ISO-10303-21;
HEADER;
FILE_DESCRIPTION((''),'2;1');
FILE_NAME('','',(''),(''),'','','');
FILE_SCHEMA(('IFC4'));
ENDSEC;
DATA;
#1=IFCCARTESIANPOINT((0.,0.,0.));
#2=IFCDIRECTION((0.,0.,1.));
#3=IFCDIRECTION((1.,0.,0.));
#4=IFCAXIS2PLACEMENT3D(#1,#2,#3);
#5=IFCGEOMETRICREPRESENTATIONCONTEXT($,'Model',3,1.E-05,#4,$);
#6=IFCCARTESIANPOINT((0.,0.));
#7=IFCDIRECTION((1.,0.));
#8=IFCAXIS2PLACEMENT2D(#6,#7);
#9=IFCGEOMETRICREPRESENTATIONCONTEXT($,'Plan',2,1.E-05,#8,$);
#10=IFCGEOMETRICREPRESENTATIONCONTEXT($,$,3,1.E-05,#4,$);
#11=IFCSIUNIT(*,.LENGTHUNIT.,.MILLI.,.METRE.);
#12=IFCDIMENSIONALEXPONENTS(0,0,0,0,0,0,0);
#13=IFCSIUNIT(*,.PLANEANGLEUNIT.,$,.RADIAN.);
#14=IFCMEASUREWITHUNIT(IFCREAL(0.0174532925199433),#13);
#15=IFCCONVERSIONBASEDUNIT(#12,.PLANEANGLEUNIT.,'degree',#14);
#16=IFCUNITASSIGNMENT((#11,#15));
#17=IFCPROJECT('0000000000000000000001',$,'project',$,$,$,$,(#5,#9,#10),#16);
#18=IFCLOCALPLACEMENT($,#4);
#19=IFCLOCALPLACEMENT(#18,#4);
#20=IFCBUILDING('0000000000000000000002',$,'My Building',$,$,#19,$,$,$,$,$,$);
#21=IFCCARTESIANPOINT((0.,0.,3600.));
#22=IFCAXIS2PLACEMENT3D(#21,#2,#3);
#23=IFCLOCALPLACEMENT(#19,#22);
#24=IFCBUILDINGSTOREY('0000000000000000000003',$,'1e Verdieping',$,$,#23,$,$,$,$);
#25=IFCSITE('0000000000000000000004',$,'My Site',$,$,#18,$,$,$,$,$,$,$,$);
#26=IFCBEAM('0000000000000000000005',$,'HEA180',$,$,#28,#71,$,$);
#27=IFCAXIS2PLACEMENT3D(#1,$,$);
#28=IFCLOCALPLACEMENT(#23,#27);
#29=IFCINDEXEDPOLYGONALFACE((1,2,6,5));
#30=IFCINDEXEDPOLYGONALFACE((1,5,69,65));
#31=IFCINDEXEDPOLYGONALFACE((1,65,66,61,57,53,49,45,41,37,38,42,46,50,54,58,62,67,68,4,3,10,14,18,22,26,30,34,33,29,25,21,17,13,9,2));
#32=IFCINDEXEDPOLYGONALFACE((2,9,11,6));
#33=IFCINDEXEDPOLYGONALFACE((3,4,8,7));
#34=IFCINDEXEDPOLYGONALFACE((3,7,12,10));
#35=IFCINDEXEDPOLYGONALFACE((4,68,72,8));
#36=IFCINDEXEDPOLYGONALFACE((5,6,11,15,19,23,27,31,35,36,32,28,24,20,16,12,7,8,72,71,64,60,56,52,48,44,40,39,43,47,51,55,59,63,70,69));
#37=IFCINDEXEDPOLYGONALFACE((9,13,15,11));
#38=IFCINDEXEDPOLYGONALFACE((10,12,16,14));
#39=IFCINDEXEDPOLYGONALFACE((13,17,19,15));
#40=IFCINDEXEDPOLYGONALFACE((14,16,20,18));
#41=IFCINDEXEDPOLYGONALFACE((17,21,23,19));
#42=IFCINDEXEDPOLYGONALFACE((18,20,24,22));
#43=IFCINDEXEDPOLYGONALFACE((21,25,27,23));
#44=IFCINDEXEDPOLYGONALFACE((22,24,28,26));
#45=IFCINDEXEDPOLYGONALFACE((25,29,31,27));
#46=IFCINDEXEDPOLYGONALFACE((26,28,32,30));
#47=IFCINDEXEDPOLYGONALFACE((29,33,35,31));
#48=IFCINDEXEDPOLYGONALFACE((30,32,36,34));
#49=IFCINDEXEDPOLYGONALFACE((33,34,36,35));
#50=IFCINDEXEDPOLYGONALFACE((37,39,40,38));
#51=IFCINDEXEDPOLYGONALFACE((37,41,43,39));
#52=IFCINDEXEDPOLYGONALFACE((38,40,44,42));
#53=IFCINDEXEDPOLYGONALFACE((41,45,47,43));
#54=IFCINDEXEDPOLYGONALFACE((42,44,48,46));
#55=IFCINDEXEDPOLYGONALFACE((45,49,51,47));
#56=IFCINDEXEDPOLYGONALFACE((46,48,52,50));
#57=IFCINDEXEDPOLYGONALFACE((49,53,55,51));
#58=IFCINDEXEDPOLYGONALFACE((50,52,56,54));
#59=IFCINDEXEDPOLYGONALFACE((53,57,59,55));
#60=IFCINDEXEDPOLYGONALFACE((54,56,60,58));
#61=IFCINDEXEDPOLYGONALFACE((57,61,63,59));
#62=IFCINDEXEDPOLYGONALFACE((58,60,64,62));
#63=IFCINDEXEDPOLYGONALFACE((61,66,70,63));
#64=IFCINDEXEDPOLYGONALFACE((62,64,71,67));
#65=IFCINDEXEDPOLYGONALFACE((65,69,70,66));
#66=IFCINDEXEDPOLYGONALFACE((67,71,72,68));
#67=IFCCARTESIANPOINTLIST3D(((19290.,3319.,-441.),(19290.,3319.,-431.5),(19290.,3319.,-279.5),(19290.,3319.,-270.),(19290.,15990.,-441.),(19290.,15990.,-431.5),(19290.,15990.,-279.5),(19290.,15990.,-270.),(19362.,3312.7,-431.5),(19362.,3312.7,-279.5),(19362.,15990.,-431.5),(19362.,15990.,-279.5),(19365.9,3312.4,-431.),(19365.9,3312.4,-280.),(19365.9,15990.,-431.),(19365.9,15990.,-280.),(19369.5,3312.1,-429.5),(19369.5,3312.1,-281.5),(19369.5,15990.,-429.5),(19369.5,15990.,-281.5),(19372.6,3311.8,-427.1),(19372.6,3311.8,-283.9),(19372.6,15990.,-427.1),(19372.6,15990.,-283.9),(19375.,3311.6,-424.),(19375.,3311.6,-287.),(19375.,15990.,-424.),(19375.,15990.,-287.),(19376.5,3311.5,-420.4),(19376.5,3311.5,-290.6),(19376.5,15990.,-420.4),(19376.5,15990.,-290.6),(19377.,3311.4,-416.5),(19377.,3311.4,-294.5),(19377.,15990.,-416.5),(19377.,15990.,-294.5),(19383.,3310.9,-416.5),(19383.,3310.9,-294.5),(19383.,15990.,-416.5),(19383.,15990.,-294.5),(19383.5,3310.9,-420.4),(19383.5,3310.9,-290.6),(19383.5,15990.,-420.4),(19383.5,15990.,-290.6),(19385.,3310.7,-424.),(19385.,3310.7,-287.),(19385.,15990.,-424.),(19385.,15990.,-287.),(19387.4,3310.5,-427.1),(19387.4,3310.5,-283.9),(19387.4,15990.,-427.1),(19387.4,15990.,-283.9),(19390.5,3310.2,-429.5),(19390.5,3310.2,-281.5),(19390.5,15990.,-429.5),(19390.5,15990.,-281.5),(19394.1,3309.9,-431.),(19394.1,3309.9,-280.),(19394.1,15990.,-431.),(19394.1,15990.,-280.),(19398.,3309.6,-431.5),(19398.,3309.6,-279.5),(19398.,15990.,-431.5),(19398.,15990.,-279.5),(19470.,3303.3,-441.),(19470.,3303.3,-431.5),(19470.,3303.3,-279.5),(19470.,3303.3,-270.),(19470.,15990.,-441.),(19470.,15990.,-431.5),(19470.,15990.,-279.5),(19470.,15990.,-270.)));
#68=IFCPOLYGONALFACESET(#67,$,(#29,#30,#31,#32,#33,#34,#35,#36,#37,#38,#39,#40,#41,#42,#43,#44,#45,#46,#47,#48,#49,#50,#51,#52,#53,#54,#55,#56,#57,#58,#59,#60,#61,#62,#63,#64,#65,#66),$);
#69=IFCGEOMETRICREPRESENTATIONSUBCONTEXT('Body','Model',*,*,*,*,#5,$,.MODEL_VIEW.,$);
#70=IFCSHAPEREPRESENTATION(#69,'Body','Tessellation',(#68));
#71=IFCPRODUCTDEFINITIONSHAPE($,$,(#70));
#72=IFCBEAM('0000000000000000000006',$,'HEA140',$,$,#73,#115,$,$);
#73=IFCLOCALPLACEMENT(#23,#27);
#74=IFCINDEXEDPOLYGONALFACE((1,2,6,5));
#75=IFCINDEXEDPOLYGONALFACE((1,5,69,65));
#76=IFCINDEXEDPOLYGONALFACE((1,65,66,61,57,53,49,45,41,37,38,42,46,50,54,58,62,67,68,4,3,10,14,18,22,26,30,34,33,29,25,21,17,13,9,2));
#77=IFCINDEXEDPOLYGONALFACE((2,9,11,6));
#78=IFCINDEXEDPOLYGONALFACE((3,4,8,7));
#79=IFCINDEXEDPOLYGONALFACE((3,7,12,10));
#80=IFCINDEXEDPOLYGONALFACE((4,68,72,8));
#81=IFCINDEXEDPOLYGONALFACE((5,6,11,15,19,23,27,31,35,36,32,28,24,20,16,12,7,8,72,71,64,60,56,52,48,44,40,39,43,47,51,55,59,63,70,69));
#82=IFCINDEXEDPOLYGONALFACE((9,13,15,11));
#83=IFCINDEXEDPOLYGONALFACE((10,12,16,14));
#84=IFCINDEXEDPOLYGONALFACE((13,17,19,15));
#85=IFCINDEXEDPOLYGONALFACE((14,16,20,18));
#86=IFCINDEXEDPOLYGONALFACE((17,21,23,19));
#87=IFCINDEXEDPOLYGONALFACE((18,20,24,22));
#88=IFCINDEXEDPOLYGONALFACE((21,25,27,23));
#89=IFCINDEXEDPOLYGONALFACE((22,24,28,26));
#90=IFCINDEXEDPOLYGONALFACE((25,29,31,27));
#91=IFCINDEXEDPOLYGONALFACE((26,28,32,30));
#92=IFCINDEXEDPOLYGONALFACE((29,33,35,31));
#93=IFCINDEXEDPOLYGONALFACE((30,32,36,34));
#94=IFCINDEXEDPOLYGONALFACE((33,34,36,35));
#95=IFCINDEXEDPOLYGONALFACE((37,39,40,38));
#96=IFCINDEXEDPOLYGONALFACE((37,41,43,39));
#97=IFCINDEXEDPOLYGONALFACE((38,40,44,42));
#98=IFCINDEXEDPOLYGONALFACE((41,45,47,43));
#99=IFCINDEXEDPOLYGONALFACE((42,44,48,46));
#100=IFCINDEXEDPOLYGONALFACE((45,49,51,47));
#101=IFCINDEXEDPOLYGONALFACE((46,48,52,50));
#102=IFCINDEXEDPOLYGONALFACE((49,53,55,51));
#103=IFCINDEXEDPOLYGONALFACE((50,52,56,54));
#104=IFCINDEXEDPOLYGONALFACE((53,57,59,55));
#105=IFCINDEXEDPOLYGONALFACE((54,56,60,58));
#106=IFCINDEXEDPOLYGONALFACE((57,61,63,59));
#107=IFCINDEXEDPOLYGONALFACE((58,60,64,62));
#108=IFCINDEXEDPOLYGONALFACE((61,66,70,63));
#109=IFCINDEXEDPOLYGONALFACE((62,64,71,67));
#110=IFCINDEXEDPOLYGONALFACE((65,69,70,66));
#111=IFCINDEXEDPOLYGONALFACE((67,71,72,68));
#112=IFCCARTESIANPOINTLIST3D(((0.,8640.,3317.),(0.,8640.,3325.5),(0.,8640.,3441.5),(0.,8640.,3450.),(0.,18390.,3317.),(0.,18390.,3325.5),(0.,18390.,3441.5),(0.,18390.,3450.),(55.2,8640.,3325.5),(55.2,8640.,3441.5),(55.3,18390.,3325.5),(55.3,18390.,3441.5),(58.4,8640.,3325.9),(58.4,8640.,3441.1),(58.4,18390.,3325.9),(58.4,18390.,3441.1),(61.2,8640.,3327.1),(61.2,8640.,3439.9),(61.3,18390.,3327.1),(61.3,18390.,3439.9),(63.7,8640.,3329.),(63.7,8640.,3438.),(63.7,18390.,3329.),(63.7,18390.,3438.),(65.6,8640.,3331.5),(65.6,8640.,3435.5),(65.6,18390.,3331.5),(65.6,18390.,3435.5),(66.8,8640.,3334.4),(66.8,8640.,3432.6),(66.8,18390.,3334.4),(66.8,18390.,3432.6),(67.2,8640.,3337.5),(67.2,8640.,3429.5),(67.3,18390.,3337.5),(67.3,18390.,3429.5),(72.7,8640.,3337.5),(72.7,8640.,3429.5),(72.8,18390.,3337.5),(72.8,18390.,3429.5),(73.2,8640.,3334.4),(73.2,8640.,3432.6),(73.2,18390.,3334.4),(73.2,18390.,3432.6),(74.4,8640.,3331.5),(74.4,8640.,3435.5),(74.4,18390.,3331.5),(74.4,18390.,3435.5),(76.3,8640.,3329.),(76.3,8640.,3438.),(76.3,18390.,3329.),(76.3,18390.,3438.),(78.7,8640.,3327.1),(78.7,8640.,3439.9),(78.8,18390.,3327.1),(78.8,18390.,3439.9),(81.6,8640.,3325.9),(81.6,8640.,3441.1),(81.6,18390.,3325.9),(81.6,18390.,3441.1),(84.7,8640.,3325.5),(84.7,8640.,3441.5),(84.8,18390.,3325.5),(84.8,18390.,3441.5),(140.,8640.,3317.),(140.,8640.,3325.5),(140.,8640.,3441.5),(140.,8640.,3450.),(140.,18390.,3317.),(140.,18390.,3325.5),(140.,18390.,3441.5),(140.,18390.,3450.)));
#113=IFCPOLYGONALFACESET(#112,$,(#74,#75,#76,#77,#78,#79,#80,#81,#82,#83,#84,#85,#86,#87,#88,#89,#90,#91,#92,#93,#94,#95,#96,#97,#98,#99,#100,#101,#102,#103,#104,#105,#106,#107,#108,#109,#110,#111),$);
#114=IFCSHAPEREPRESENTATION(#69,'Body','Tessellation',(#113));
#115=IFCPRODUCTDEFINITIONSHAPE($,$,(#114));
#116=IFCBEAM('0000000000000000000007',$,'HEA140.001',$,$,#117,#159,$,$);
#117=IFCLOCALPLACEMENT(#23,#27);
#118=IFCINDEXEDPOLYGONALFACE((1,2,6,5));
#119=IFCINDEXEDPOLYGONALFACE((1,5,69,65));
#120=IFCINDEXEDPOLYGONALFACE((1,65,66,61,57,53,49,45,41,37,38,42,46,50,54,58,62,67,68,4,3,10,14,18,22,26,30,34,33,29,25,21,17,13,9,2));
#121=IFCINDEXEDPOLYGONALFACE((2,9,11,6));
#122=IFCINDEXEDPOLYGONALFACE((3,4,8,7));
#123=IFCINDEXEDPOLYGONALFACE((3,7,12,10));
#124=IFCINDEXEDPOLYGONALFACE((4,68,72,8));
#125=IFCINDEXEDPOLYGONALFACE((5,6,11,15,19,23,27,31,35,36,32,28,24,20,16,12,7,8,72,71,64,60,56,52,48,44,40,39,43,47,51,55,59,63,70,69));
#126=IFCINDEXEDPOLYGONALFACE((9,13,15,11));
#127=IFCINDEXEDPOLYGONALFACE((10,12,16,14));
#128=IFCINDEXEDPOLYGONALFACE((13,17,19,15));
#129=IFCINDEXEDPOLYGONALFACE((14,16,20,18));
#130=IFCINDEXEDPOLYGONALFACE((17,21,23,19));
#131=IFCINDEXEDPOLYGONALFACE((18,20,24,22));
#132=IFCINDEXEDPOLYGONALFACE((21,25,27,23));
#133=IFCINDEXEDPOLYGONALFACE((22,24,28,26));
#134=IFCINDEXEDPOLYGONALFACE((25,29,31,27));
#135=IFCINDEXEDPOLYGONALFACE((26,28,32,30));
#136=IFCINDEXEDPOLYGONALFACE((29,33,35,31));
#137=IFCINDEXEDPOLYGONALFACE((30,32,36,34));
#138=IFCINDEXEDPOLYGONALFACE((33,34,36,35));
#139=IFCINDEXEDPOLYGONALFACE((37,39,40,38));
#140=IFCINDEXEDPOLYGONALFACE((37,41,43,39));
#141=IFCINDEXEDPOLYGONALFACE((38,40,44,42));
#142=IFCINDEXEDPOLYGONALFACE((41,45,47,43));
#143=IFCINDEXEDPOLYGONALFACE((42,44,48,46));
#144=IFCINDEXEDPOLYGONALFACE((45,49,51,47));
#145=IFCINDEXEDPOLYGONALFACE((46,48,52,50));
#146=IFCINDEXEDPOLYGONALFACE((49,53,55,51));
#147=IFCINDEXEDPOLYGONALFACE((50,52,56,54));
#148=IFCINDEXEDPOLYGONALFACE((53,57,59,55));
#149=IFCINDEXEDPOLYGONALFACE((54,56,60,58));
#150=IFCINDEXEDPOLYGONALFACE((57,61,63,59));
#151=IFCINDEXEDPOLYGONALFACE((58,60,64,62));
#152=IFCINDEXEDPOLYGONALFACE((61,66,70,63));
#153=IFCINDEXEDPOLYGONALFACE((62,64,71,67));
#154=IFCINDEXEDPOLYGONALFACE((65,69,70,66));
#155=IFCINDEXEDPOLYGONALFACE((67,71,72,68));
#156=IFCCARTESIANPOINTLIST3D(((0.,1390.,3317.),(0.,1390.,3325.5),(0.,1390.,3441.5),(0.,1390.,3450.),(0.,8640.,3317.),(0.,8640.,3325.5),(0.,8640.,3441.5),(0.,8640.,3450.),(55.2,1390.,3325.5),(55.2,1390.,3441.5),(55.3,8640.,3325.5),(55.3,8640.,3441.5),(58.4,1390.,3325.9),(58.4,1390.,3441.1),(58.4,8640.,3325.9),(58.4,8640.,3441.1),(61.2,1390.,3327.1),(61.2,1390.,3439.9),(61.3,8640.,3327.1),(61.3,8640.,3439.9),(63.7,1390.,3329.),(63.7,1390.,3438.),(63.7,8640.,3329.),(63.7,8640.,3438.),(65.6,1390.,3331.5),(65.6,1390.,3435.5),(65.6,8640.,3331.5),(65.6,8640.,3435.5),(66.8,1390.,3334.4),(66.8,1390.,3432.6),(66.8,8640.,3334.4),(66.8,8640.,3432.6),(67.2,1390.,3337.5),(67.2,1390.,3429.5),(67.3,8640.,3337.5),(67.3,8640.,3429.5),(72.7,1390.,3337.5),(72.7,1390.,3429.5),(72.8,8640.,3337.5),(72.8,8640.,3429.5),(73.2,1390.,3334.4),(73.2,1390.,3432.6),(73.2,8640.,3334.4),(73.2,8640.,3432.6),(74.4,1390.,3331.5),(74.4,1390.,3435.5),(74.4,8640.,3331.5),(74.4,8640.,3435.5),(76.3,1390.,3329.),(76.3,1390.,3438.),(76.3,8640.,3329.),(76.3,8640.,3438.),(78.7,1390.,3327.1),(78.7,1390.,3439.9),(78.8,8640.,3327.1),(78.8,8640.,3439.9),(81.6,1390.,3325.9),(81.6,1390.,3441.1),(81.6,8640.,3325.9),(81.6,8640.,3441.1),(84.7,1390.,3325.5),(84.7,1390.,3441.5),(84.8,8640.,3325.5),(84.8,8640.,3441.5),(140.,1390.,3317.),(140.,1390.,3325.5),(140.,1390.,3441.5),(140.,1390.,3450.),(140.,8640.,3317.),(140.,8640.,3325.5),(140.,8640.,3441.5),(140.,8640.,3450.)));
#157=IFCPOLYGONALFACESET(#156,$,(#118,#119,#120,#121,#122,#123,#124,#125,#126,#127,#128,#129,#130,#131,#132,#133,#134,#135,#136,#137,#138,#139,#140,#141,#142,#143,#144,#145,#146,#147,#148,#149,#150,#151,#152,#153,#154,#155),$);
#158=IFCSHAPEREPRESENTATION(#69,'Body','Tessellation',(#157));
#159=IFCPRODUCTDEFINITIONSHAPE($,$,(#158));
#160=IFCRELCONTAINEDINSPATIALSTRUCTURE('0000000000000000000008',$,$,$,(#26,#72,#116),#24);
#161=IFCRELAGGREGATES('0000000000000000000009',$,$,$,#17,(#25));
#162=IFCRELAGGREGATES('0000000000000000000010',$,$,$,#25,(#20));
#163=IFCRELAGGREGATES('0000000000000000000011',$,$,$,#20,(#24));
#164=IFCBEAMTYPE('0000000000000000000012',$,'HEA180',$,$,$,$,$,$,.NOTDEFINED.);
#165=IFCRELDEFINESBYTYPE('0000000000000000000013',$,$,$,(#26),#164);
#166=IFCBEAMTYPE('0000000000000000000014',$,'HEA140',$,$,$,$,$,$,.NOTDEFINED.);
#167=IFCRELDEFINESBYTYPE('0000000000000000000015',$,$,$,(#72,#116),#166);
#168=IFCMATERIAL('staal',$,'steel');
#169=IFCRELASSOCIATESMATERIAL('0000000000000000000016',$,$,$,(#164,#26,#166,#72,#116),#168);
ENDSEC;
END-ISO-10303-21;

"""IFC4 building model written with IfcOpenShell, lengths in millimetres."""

from ifc_helpers import new_model, entity, si_unit, converted_unit, frame, origin_with_axes, origin_2d_with_axis, place, context, subcontext, project, spatial, i_section, extrude, clip, halfspace, material, material_profile, profile_set, profile_usage, type_object, element, save


model = new_model("IFC4")

# Units and contexts
model_context = context("Model", 3, precision=1e-05, world=origin_with_axes())
plan_context = context("Plan", 2, precision=1e-05, world=origin_2d_with_axis())
context_of_model = context(None, 3, precision=1e-05, world=origin_with_axes())
body_context = subcontext(model_context, "Body", "Model", "MODEL_VIEW")
ifc_project = project(units=[si_unit("LENGTHUNIT", "METRE", prefix="MILLI"), converted_unit("PLANEANGLEUNIT", "degree", entity("IfcReal", 0.0174532925199433), si_unit("PLANEANGLEUNIT", "RADIAN"), dimensions=[0, 0, 0, 0, 0, 0, 0])], contexts=[model_context, plan_context, context_of_model])

# Site, building, storey
site_placement = place(None, origin_with_axes())
site = spatial("IfcSite", under=ifc_project, at=site_placement, Name="My Site")
building_placement = place(site_placement, origin_with_axes())
building = spatial("IfcBuilding", under=site, at=building_placement, Name="My Building")
storey_placement = place(building_placement, frame((0.0, 0.0, 3600.0), z_axis=(0.0, 0.0, 1.0), x_axis=(1.0, 0.0, 0.0)))
storey = spatial("IfcBuildingStorey", under=building, at=storey_placement, Name="1e Verdieping")

# Shared definitions
ifc_material_1 = material(Name="staal", Category="steel")

# Beams
ifc_material_profile_1 = material_profile(ifc_material_1, i_section(OverallWidth=180.0, OverallDepth=171.0, WebThickness=6.0, FlangeThickness=9.5, FilletRadius=15.0))
ifc_profile_set_1 = profile_set([ifc_material_profile_1], Name="HEA180")
ifc_profile_usage_1 = profile_usage(ifc_profile_set_1)
beam_type_1 = type_object("IfcBeamType", Name="HEA180", PredefinedType="NOTDEFINED", material=ifc_profile_set_1)
beam_1_placement = place(storey_placement, frame((19380.0, 15990.0, -355.5), z_axis=(0.0, -1.0, 0.0), x_axis=(1.0, 0.0, 0.0)))
element("IfcBeam", 1, at=beam_1_placement, inside=storey, type_object=beam_type_1, material=ifc_profile_usage_1, Name="HEA180", context=body_context, shape_type="Clipping", body=[
    clip(extrude(i_section(OverallWidth=180.0, OverallDepth=171.0, WebThickness=6.0, FlangeThickness=9.5, FilletRadius=15.0), origin_with_axes(), (0.0, 0.0, 1.0), 13377.1), halfspace(frame((90.0, -3244.5, 12686.7), z_axis=(-0.087123, 0.0, 0.996198), x_axis=(-0.000001, 1.0, 0.0)), False)),
])
ifc_material_profile_2 = material_profile(ifc_material_1, i_section(OverallWidth=140.0, OverallDepth=133.0, WebThickness=5.5, FlangeThickness=8.5, FilletRadius=12.0))
ifc_profile_set_2 = profile_set([ifc_material_profile_2], Name="HEA140")
ifc_profile_usage_2 = profile_usage(ifc_profile_set_2)
beam_type_2 = type_object("IfcBeamType", Name="HEA140", PredefinedType="NOTDEFINED", material=ifc_profile_set_2)
beam_2_placement = place(storey_placement, frame((70.0, 18390.0, 3383.5), z_axis=(0.0, -1.0, 0.0), x_axis=(1.0, 0.0, 0.0)))
element("IfcBeam", 2, at=beam_2_placement, inside=storey, type_object=beam_type_2, material=ifc_profile_usage_2, Name="HEA140", context=body_context, shape_type="SweptSolid", body=[
    extrude(i_section(OverallWidth=140.0, OverallDepth=133.0, WebThickness=5.5, FlangeThickness=8.5, FilletRadius=12.0), origin_with_axes(), (0.0, 0.0, 1.0), 9750.0),
])
ifc_profile_usage_3 = profile_usage(ifc_profile_set_2)
beam_3_placement = place(storey_placement, frame((70.0, 8640.0, 3383.5), z_axis=(0.0, -1.0, 0.0), x_axis=(1.0, 0.0, 0.0)))
element("IfcBeam", 3, at=beam_3_placement, inside=storey, type_object=beam_type_2, material=ifc_profile_usage_3, Name="HEA140.001", context=body_context, shape_type="SweptSolid", body=[
    extrude(i_section(OverallWidth=140.0, OverallDepth=133.0, WebThickness=5.5, FlangeThickness=8.5, FilletRadius=12.0), origin_with_axes(), (0.0, 0.0, 1.0), 7250.0),
])

save(model, "model.ifc")
